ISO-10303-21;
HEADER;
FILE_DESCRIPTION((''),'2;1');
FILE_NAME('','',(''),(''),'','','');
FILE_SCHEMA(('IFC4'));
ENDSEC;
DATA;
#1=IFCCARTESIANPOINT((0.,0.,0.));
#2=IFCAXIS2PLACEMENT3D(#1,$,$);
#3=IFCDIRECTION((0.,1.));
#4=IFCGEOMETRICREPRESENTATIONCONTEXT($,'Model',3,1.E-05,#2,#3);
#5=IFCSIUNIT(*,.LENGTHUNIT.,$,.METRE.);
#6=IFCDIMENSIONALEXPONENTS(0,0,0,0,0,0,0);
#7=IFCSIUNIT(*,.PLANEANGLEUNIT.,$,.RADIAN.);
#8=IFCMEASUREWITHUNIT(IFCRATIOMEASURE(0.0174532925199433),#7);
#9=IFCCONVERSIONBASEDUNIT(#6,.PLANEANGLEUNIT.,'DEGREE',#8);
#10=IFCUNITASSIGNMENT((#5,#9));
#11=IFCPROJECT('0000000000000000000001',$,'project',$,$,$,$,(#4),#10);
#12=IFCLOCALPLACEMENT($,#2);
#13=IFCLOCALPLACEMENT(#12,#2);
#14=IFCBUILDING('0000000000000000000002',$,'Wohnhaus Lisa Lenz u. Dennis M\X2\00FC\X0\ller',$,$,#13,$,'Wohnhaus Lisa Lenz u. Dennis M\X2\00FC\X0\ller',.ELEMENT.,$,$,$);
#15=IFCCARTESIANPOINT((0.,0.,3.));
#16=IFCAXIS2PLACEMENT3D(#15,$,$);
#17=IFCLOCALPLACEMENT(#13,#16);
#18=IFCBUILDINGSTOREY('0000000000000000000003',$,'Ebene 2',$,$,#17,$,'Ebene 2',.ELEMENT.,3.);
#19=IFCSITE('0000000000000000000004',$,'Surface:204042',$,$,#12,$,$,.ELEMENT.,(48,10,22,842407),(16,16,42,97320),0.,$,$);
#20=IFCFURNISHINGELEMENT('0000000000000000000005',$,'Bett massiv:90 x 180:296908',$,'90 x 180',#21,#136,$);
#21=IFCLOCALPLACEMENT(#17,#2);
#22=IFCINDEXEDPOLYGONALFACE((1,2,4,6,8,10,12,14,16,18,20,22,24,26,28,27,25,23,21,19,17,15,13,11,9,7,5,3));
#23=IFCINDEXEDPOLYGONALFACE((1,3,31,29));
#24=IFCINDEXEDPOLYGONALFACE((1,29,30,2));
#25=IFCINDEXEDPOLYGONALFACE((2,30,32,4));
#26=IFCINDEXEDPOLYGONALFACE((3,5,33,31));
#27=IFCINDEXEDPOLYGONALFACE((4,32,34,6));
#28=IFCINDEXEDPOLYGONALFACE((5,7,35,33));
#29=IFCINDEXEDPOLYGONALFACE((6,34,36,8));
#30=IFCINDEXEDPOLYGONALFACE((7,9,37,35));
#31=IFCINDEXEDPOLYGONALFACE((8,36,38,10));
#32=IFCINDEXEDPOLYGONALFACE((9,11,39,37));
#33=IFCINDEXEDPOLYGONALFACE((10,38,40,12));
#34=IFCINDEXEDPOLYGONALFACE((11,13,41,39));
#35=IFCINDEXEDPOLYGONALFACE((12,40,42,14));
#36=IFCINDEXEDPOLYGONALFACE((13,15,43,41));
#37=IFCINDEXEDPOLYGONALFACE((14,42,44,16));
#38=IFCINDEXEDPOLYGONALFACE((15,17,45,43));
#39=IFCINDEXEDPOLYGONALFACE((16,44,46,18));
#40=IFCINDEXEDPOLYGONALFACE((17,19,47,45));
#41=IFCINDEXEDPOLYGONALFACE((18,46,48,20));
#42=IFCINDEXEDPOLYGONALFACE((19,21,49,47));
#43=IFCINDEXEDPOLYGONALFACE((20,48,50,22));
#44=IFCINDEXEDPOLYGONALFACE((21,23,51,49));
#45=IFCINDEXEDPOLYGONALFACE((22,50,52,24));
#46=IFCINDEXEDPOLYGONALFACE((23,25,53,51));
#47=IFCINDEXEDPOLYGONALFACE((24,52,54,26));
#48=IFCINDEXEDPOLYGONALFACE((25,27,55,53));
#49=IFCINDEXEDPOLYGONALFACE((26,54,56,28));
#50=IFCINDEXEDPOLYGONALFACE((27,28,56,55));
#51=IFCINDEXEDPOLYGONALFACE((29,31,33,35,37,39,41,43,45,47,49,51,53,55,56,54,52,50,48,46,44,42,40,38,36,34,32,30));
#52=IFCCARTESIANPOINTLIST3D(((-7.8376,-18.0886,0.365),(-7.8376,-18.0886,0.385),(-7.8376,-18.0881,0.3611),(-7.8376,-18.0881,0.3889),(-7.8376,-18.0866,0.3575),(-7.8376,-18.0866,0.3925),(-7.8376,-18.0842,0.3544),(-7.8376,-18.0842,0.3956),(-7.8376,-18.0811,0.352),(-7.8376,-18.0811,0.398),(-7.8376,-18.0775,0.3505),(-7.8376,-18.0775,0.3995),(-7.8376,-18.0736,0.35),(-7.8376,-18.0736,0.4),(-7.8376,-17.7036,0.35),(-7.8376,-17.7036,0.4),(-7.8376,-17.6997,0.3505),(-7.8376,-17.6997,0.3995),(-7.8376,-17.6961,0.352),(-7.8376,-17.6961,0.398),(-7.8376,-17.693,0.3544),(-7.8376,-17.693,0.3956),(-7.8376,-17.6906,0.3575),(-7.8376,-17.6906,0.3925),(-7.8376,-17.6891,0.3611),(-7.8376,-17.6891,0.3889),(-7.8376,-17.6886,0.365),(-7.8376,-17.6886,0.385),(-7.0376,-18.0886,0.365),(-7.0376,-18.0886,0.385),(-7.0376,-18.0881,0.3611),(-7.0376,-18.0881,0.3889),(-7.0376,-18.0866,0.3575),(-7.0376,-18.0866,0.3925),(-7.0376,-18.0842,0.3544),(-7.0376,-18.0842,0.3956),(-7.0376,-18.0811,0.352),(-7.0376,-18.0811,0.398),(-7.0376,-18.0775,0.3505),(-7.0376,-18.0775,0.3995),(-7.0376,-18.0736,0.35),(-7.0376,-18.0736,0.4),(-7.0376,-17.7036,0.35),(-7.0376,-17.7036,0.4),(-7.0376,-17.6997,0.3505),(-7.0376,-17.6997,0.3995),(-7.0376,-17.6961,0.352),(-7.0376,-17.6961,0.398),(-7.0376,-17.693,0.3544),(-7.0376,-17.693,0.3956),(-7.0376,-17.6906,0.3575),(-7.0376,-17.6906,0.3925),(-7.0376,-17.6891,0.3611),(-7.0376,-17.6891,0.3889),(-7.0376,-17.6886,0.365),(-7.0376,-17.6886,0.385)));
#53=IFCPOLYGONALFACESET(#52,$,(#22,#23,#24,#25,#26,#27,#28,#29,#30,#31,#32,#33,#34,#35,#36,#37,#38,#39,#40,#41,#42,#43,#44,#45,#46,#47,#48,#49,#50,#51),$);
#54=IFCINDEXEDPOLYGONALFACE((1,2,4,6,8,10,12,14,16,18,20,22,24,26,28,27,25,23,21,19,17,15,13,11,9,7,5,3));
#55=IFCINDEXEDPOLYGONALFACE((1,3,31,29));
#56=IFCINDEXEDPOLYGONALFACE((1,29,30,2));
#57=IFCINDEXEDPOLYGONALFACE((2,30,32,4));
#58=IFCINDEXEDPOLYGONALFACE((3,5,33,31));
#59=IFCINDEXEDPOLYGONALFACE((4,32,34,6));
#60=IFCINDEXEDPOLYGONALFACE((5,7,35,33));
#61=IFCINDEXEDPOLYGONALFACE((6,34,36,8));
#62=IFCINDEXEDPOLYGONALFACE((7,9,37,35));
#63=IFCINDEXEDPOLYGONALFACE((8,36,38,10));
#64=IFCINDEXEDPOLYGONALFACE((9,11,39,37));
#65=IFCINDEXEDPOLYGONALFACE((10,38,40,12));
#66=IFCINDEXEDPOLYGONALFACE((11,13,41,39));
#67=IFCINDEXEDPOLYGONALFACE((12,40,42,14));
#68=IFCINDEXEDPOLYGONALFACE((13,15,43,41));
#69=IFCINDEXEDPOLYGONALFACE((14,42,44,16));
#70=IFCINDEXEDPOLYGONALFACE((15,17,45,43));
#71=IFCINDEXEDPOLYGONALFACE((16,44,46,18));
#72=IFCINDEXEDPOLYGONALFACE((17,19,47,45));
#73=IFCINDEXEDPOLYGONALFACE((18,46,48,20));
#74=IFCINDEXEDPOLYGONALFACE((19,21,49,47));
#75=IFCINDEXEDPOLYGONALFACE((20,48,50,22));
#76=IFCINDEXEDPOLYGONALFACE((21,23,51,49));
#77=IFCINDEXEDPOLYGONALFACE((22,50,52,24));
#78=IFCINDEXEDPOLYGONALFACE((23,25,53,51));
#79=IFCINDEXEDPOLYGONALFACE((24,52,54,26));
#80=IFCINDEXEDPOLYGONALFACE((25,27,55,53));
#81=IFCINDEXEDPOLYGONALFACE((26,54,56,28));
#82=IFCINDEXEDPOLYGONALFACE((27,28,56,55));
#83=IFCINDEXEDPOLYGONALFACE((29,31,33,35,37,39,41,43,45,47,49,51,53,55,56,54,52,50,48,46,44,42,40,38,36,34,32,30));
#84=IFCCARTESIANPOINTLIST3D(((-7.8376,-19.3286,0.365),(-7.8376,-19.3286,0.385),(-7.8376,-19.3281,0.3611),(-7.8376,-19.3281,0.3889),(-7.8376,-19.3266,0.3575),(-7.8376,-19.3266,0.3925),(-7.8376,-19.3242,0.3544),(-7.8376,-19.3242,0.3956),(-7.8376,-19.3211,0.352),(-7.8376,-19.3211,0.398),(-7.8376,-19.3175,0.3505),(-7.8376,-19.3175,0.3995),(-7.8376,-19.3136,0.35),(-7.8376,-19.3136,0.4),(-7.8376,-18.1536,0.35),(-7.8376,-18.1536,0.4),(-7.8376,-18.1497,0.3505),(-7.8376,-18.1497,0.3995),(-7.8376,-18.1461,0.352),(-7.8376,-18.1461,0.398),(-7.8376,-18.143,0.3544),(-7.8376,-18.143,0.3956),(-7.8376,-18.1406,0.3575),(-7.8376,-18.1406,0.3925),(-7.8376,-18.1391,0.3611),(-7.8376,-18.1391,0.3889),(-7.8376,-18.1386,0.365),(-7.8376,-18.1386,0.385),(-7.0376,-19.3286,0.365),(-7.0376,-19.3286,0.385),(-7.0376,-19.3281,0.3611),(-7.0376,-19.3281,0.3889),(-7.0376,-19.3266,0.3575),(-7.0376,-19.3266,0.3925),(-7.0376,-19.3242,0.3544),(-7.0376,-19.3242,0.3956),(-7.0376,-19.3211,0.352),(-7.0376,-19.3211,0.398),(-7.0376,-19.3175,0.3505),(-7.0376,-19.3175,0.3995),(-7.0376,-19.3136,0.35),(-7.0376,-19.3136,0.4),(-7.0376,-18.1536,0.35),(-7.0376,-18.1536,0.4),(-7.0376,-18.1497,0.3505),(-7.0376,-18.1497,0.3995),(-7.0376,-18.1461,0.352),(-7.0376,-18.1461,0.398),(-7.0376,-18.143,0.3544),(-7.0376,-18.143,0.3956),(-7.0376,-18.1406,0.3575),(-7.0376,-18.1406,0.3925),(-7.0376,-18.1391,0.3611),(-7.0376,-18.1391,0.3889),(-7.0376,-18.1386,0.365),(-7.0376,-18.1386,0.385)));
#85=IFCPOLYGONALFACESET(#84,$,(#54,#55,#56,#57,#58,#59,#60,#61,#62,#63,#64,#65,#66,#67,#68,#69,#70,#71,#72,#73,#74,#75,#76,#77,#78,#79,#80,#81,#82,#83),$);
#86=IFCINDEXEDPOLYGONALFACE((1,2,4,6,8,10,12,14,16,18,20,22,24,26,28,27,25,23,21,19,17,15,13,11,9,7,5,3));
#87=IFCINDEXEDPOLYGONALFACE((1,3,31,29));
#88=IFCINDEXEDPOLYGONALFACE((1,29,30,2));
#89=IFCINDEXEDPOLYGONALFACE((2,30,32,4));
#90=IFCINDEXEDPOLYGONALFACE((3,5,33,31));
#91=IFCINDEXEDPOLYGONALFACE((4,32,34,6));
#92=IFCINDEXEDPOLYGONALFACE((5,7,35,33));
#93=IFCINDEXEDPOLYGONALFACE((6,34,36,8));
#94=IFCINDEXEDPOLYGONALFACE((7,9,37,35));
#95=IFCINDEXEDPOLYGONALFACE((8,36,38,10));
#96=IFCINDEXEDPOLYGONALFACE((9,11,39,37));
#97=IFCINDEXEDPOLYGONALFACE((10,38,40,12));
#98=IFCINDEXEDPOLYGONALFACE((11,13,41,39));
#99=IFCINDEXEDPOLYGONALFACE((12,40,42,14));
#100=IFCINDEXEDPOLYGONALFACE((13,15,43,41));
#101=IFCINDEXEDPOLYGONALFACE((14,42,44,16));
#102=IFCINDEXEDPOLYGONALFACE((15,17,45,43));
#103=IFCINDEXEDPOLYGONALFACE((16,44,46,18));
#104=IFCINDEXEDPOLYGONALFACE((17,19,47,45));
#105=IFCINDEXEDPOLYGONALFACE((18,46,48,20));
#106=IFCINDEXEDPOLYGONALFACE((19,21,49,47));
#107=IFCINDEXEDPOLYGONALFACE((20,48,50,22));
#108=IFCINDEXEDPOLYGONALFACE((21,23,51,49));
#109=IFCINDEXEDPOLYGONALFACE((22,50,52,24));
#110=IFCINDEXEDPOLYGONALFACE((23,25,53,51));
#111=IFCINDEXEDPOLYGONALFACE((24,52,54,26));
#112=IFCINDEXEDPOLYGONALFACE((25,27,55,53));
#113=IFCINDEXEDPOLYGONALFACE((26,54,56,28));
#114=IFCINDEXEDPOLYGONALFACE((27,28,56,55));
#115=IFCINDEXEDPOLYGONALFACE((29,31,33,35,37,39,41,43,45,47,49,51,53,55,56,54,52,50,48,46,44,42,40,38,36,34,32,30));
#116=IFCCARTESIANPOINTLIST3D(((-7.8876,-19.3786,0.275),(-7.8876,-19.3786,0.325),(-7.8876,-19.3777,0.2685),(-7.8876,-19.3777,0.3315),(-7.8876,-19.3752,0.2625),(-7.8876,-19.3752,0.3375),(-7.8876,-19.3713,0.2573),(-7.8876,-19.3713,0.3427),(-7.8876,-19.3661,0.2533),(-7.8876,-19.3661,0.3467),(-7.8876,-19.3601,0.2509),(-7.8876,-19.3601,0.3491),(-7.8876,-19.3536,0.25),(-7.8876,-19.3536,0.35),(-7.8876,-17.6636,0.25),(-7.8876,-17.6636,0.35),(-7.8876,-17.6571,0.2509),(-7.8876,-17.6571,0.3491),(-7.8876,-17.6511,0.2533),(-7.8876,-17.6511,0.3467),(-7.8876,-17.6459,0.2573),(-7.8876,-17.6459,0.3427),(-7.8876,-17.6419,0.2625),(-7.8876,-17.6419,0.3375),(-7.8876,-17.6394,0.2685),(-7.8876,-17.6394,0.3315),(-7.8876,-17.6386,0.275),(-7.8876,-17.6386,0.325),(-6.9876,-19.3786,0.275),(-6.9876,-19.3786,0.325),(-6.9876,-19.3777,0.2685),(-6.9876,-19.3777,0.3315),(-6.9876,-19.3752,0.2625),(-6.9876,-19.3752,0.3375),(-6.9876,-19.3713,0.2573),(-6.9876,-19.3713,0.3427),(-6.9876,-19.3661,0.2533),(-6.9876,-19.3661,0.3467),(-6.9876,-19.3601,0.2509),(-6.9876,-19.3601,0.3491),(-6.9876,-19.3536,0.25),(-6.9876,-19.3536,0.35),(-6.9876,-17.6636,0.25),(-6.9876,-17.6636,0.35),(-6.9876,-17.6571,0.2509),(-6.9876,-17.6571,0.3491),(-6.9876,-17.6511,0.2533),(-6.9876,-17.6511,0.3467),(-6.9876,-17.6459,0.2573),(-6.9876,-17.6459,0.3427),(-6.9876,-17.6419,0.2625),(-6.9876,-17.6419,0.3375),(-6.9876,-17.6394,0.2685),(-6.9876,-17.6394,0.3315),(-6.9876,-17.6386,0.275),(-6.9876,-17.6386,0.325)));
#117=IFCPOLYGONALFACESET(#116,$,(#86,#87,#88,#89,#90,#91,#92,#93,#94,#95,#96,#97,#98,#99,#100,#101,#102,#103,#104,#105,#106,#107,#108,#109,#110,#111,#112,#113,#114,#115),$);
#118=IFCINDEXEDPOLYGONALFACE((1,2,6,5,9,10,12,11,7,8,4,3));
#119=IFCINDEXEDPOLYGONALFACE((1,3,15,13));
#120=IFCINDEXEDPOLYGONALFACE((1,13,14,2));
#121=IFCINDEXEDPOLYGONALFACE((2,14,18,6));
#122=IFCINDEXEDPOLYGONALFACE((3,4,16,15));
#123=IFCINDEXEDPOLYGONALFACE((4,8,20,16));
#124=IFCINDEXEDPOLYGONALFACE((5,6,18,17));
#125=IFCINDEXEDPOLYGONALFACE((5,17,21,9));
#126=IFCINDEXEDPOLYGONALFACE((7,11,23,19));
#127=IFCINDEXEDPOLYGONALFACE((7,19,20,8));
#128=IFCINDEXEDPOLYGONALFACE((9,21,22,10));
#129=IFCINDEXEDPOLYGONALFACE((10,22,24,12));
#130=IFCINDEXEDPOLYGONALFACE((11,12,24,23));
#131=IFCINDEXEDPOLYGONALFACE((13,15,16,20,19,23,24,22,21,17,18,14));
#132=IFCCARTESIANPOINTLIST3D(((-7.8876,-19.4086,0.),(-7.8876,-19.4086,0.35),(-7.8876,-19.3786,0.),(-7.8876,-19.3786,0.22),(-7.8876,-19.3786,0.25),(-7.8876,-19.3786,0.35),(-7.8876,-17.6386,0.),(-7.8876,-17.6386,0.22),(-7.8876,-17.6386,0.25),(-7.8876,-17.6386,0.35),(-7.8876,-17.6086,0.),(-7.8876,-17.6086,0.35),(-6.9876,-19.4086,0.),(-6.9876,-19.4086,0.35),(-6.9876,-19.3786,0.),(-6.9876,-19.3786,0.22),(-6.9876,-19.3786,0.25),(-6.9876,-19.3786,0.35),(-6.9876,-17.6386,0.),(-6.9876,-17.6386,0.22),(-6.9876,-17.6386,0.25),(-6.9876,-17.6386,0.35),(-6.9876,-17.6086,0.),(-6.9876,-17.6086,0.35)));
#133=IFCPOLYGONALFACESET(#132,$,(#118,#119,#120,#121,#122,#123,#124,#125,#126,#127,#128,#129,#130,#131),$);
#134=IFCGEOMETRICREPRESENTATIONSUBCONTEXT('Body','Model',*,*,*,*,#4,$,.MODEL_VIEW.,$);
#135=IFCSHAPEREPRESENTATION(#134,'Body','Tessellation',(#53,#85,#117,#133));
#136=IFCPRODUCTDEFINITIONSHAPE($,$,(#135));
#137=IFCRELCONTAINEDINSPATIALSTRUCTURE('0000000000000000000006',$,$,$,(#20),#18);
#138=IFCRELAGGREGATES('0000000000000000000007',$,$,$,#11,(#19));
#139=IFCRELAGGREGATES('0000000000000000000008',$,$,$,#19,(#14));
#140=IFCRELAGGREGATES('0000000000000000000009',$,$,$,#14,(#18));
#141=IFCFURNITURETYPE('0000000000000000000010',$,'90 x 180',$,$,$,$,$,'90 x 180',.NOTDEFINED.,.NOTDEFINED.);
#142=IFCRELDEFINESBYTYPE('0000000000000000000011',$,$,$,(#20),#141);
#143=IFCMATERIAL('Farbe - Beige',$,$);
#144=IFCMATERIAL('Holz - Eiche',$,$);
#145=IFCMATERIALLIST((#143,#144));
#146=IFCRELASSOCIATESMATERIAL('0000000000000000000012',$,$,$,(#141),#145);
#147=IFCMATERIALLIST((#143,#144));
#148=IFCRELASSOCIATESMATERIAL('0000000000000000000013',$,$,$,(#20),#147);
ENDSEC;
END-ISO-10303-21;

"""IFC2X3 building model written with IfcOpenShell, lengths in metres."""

from ifc_helpers import new_model, entity, si_unit, converted_unit, direction, frame, frame_2d, origin, place, context, subcontext, project, spatial, polyline, circle_curve, parameter, trimmed, segment, composite_curve, outline, extrude, source, transform, mapped, material, material_list, type_object, type_shapes, element, save


model = new_model("IFC2X3")

# Units and contexts
model_context = context("Model", 3, precision=1e-05, world=origin(), true_north=direction((0.0, 1.0)))
body_context = subcontext(model_context, "Body", "Model", "MODEL_VIEW")
ifc_project = project(units=[si_unit("LENGTHUNIT", "METRE"), converted_unit("PLANEANGLEUNIT", "DEGREE", entity("IfcRatioMeasure", 0.0174532925199433), si_unit("PLANEANGLEUNIT", "RADIAN"), dimensions=[0, 0, 0, 0, 0, 0, 0])], contexts=[model_context])

# Site, building, storey
site_placement = place(None, origin())
site = spatial("IfcSite", under=ifc_project, at=site_placement, Name="Surface:204042", CompositionType="ELEMENT", RefLatitude=(48, 10, 22, 842407), RefLongitude=(16, 16, 42, 97320), RefElevation=0.0)
building_placement = place(site_placement, origin())
building = spatial("IfcBuilding", under=site, at=building_placement, Name="Wohnhaus Lisa Lenz u. Dennis Müller", LongName="Wohnhaus Lisa Lenz u. Dennis Müller", CompositionType="ELEMENT")
storey_placement = place(building_placement, frame((0.0, 0.0, 3.0)))
storey = spatial("IfcBuildingStorey", under=building, at=storey_placement, Name="Ebene 2", LongName="Ebene 2", CompositionType="ELEMENT", Elevation=3.0)

# Furnishing element
ifc_material_1 = material(Name="Farbe - Beige")
ifc_material_2 = material(Name="Holz - Eiche")
ifc_material_list_1 = material_list([ifc_material_1, ifc_material_2])
ifc_material_list_2 = material_list([ifc_material_1, ifc_material_2])
furniture_type_1 = type_object("IfcFurnitureType", Name="90 x 180", ElementType="90 x 180", material=ifc_material_list_2)
shared_shape_1 = source(origin(), body_context, "Body", "SweptSolid", [
    extrude(outline(composite_curve([segment(trimmed(circle_curve(frame_2d((-0.185, 0.01), x_axis=(1.0, 0.0)), 0.015), [parameter(90.0)], [parameter(180.0)], True, "PARAMETER"), True, "CONTINUOUS"), segment(polyline([(-0.2, 0.01), (-0.2, -0.01)]), True, "CONTINUOUS"), segment(trimmed(circle_curve(frame_2d((-0.185, -0.01), x_axis=(1.0, 0.0)), 0.015), [parameter(180.0)], [parameter(270.0)], True, "PARAMETER"), True, "CONTINUOUS"), segment(polyline([(-0.185, -0.025), (0.185, -0.025)]), True, "CONTINUOUS"), segment(trimmed(circle_curve(frame_2d((0.185, -0.01), x_axis=(1.0, 0.0)), 0.015), [parameter(270.0)], [parameter(0.0)], True, "PARAMETER"), True, "CONTINUOUS"), segment(polyline([(0.2, -0.01), (0.2, 0.01)]), True, "CONTINUOUS"), segment(trimmed(circle_curve(frame_2d((0.185, 0.01), x_axis=(1.0, 0.0)), 0.015), [parameter(0.0)], [parameter(90.0)], True, "PARAMETER"), True, "CONTINUOUS"), segment(polyline([(0.185, 0.025), (-0.185, 0.025)]), True, "CONTINUOUS")], self_intersect=False)), frame((-0.4, 0.62, 0.375), z_axis=(1.0, 0.0, 0.0), x_axis=(0.0, 1.0, 0.0)), (0.0, 0.0, 1.0), 0.8),
    extrude(outline(composite_curve([segment(trimmed(circle_curve(frame_2d((0.58, -0.01), x_axis=(1.0, 0.0)), 0.015), [parameter(270.0)], [parameter(0.0)], True, "PARAMETER"), True, "CONTINUOUS"), segment(polyline([(0.595, -0.01), (0.595, 0.01)]), True, "CONTINUOUS"), segment(trimmed(circle_curve(frame_2d((0.58, 0.01), x_axis=(1.0, 0.0)), 0.015), [parameter(0.0)], [parameter(90.0)], True, "PARAMETER"), True, "CONTINUOUS"), segment(polyline([(0.58, 0.025), (-0.58, 0.025)]), True, "CONTINUOUS"), segment(trimmed(circle_curve(frame_2d((-0.58, 0.01), x_axis=(1.0, 0.0)), 0.015), [parameter(90.0)], [parameter(180.0)], True, "PARAMETER"), True, "CONTINUOUS"), segment(polyline([(-0.595, 0.01), (-0.595, -0.01)]), True, "CONTINUOUS"), segment(trimmed(circle_curve(frame_2d((-0.58, -0.01), x_axis=(1.0, 0.0)), 0.015), [parameter(180.0)], [parameter(270.0)], True, "PARAMETER"), True, "CONTINUOUS"), segment(polyline([(-0.58, -0.025), (0.58, -0.025)]), True, "CONTINUOUS")], self_intersect=False)), frame((-0.4, -0.225, 0.375), z_axis=(1.0, 0.0, 0.0), x_axis=(0.0, 1.0, 0.0)), (0.0, 0.0, 1.0), 0.8),
    extrude(outline(composite_curve([segment(polyline([(-0.845, -0.05), (0.845, -0.05)]), True, "CONTINUOUS"), segment(trimmed(circle_curve(frame_2d((0.845, -0.025), x_axis=(-1.0, 0.0)), 0.025), [parameter(90.0)], [parameter(180.0)], True, "PARAMETER"), True, "CONTINUOUS"), segment(polyline([(0.87, -0.025), (0.87, 0.025)]), True, "CONTINUOUS"), segment(trimmed(circle_curve(frame_2d((0.845, 0.025), x_axis=(-1.0, 0.0)), 0.025), [parameter(180.0)], [parameter(270.0)], True, "PARAMETER"), True, "CONTINUOUS"), segment(polyline([(0.845, 0.05), (-0.845, 0.05)]), True, "CONTINUOUS"), segment(trimmed(circle_curve(frame_2d((-0.845, 0.025), x_axis=(-1.0, 0.0)), 0.025), [parameter(270.0)], [parameter(0.0)], True, "PARAMETER"), True, "CONTINUOUS"), segment(polyline([(-0.87, 0.025), (-0.87, -0.025)]), True, "CONTINUOUS"), segment(trimmed(circle_curve(frame_2d((-0.845, -0.025), x_axis=(-1.0, 0.0)), 0.025), [parameter(360.0)], [parameter(90.0)], True, "PARAMETER"), True, "CONTINUOUS")], self_intersect=False)), frame((-0.45, 0.0, 0.3), z_axis=(1.0, 0.0, 0.0), x_axis=(0.0, -1.0, 0.0)), (0.0, 0.0, 1.0), 0.9),
    extrude(outline(polyline([(-0.87, 0.055), (-0.87, 0.155), (-0.9, 0.155), (-0.9, -0.195), (-0.87, -0.195), (-0.87, 0.025), (0.87, 0.025), (0.87, -0.195), (0.9, -0.195), (0.9, 0.155), (0.87, 0.155), (0.87, 0.055), (-0.87, 0.055)])), frame((-0.45, 0.0, 0.195), z_axis=(-1.0, 0.0, 0.0), x_axis=(0.0, -1.0, 0.0)), (0.0, 0.0, -1.0), 0.9),
])
type_shapes(furniture_type_1, [shared_shape_1])
furnishing_1_placement = place(storey_placement, frame((-7.4376, -18.5086, 0.0)))
element("IfcFurnishingElement", 1, at=furnishing_1_placement, inside=storey, type_object=furniture_type_1, material=ifc_material_list_1, Name="Bett massiv:90 x 180:296908", ObjectType="90 x 180", context=body_context, shape_type="MappedRepresentation", body=[
    mapped(shared_shape_1, transform((0.0, 0.0, 0.0), scale=1.0)),
])

save(model, "model.ifc")
